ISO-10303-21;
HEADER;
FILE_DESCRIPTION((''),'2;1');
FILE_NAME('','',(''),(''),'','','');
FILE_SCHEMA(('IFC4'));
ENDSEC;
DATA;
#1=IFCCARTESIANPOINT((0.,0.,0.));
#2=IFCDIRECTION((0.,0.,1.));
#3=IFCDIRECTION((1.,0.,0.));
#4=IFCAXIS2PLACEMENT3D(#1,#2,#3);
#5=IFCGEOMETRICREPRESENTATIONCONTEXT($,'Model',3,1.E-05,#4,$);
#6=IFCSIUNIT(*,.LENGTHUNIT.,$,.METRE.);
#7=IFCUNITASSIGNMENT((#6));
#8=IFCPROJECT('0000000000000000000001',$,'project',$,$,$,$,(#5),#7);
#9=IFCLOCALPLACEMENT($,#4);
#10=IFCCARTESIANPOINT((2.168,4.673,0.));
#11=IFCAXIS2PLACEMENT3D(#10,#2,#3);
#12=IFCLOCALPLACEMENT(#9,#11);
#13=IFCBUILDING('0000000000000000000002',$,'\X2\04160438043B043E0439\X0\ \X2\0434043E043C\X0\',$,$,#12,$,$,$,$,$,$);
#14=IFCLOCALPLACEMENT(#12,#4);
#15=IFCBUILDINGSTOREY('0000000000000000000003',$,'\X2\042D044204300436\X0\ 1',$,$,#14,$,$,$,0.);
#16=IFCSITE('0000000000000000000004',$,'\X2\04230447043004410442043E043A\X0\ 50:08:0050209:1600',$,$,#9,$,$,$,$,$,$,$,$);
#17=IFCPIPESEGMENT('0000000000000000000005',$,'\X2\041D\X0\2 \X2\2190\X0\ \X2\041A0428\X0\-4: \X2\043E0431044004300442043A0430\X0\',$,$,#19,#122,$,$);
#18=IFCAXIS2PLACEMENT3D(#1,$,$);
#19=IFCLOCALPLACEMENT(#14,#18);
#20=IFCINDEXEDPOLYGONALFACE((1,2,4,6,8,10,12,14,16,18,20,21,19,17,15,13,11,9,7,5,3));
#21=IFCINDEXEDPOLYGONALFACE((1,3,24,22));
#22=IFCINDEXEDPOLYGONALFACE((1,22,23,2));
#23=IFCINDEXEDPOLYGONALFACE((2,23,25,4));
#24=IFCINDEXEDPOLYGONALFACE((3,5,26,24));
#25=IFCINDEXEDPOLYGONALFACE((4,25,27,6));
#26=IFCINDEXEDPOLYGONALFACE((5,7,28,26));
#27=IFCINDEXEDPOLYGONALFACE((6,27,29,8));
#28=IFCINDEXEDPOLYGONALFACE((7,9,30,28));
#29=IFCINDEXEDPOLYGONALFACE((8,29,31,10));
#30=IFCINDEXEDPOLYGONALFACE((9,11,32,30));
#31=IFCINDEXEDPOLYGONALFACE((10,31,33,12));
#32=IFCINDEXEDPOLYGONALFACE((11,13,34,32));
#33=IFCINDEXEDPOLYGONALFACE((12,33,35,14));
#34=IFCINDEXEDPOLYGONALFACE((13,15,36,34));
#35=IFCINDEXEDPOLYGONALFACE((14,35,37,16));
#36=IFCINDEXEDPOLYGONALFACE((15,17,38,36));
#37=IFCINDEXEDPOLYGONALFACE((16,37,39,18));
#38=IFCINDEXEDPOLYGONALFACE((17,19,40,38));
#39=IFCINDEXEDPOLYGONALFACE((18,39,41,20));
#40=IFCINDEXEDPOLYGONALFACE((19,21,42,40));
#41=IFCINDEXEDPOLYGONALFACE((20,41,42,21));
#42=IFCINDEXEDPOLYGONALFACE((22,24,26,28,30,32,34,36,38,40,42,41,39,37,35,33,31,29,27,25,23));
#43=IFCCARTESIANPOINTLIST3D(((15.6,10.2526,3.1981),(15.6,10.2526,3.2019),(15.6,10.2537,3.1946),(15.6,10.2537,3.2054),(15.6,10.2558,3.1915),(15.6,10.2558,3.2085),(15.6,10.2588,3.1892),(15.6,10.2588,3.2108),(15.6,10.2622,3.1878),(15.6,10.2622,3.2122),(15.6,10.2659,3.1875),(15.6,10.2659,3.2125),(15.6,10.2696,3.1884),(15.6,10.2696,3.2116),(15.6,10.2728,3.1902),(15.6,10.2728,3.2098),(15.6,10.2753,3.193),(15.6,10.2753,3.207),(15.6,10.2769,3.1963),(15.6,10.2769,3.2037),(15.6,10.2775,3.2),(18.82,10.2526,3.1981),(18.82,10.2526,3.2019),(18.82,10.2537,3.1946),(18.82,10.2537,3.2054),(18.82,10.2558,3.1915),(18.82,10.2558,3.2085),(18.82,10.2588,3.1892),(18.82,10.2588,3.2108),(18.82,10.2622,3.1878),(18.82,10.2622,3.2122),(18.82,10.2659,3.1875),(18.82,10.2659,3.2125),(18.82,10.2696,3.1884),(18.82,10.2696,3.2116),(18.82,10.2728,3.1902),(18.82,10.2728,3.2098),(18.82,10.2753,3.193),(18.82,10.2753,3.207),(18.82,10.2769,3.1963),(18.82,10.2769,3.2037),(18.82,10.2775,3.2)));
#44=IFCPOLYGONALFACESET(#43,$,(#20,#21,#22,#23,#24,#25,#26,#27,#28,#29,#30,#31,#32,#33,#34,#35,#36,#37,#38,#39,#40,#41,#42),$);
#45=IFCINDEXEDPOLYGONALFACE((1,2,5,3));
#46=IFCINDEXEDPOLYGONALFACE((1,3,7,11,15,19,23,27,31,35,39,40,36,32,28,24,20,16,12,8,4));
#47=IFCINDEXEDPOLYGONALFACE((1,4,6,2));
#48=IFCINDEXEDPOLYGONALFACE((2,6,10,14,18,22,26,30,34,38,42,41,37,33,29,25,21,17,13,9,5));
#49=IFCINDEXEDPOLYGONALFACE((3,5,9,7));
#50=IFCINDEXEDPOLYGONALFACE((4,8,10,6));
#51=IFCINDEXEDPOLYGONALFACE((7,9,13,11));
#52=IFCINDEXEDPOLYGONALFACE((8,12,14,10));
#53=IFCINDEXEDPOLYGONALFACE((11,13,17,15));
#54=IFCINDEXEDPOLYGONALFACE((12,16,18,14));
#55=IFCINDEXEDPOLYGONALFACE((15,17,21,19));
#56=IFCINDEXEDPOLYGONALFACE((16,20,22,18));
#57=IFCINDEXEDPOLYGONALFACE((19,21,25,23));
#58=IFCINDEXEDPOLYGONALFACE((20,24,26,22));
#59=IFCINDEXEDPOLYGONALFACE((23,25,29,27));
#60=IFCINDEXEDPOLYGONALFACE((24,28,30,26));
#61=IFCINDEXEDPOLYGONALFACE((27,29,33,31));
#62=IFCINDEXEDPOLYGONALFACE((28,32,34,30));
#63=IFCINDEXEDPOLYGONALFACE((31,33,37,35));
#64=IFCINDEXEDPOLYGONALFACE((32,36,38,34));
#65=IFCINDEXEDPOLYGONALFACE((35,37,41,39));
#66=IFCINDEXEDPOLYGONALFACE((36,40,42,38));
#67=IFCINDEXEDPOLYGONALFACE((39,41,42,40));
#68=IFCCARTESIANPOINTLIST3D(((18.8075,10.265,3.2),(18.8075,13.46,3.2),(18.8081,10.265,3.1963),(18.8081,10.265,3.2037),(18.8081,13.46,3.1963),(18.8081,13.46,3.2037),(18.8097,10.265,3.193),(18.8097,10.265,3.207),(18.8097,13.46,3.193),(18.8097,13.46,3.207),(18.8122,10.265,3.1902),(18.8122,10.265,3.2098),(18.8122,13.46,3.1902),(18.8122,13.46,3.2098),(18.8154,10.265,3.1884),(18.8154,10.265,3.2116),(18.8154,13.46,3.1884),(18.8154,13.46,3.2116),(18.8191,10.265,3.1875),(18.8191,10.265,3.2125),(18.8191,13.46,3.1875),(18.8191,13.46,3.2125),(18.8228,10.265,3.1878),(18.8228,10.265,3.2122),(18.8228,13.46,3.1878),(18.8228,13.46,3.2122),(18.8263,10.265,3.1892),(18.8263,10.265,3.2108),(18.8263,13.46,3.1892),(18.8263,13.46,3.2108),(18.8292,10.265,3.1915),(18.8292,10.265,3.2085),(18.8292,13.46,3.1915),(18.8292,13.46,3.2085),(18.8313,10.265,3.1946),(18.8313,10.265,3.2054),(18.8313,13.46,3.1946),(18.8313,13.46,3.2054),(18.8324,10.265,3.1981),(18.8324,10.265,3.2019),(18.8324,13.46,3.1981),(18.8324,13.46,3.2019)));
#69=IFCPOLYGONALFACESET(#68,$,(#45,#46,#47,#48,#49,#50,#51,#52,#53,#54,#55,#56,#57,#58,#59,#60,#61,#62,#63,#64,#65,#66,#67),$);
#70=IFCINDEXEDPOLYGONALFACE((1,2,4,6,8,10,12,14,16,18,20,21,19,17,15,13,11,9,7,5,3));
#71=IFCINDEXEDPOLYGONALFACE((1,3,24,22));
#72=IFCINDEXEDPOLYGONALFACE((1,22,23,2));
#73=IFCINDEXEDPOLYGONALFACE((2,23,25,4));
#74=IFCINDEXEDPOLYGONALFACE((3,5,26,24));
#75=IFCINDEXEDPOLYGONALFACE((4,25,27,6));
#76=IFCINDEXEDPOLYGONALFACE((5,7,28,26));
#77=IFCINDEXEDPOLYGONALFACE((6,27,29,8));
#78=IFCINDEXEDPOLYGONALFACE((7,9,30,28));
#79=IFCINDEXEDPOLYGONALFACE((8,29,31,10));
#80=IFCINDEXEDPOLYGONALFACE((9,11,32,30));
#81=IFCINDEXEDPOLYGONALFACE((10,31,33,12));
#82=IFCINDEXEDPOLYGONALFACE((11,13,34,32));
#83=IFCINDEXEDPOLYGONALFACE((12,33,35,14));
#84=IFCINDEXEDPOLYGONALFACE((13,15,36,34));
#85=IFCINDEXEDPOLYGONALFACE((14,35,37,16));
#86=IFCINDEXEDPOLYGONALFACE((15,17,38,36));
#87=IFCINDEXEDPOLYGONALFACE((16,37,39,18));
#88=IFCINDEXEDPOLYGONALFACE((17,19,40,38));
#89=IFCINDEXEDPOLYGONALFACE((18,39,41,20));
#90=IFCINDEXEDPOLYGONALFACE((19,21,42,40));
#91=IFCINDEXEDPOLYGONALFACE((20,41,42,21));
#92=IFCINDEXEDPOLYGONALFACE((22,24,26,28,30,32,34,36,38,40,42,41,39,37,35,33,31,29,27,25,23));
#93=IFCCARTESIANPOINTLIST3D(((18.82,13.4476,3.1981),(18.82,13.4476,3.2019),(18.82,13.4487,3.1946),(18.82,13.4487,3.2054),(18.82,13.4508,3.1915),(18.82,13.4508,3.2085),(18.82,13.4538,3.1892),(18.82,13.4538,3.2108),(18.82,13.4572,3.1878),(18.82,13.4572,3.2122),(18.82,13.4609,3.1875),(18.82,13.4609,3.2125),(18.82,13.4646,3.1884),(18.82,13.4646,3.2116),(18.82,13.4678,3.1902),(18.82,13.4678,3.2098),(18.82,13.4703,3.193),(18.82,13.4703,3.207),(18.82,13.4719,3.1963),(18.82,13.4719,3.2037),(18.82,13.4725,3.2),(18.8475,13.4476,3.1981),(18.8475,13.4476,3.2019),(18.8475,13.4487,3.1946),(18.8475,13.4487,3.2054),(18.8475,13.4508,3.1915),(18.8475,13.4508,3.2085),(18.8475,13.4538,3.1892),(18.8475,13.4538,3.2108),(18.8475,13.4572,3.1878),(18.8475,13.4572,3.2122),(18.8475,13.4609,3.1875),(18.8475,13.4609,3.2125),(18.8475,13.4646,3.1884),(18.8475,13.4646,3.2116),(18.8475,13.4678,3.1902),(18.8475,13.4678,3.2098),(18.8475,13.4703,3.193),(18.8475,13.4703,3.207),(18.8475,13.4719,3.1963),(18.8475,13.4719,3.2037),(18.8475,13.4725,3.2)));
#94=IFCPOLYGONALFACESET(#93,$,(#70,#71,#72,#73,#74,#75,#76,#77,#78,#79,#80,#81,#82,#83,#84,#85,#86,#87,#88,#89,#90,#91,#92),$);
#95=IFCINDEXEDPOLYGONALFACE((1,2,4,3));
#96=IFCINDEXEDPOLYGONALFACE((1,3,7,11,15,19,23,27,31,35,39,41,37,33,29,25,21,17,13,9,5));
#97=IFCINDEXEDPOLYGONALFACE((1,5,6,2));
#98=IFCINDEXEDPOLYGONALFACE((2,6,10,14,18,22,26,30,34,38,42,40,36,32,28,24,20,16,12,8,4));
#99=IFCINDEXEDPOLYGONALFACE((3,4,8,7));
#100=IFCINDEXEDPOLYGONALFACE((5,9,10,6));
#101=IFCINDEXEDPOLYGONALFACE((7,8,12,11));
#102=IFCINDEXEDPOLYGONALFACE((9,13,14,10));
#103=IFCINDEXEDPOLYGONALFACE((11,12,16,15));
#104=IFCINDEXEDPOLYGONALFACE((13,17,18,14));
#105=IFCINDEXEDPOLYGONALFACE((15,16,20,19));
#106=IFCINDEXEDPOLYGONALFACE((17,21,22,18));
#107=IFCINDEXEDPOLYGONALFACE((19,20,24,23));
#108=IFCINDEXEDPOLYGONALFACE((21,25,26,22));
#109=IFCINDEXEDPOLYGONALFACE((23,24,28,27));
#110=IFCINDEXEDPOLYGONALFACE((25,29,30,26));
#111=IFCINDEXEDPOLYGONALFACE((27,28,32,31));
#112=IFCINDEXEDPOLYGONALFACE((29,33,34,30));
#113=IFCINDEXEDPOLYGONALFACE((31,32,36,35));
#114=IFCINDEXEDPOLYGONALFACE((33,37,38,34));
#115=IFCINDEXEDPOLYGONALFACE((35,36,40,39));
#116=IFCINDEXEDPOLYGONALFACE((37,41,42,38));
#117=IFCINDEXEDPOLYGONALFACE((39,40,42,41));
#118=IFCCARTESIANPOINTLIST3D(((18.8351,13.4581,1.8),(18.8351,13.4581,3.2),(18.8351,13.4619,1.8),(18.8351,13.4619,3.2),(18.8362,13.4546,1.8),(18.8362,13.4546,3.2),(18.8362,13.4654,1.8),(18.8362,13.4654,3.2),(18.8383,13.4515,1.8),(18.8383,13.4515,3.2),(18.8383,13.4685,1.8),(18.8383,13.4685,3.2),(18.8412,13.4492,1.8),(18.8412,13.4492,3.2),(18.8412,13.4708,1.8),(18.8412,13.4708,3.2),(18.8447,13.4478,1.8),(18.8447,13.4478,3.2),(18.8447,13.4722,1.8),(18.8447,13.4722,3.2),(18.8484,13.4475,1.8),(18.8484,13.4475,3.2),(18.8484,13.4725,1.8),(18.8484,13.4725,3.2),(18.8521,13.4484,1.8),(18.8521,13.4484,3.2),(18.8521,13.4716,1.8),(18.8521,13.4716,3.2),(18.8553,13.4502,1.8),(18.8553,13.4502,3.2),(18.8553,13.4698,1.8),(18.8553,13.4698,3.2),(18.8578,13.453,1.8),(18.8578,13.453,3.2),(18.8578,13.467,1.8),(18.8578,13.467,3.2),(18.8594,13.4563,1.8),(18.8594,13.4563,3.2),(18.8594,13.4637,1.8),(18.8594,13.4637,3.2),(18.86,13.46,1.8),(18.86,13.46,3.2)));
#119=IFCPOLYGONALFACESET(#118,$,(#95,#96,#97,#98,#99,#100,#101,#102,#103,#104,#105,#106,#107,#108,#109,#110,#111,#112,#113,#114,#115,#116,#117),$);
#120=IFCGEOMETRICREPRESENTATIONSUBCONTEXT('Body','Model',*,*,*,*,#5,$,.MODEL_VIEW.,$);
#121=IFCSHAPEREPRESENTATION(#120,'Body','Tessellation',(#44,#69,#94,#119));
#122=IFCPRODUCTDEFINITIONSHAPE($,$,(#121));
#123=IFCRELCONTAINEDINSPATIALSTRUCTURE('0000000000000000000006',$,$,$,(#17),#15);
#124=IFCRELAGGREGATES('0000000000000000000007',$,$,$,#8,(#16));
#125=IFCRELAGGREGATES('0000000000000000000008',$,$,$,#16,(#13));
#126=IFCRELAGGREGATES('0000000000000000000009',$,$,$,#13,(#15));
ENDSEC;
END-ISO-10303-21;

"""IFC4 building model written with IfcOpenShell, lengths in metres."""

from ifc_helpers import new_model, si_unit, frame, origin_with_axes, origin_2d, place, context, subcontext, project, spatial, circle, extrude, element, save


model = new_model("IFC4")

# Units and contexts
model_context = context("Model", 3, precision=1e-05, world=origin_with_axes())
body_context = subcontext(model_context, "Body", "Model", "MODEL_VIEW")
ifc_project = project(units=[si_unit("LENGTHUNIT", "METRE")], contexts=[model_context])

# Site, building, storey
site_placement = place(None, origin_with_axes())
site = spatial("IfcSite", under=ifc_project, at=site_placement, Name="Участок 50:08:0050209:1600")
building_placement = place(site_placement, frame((2.168, 4.673, 0.0), z_axis=(0.0, 0.0, 1.0), x_axis=(1.0, 0.0, 0.0)))
building = spatial("IfcBuilding", under=site, at=building_placement, Name="Жилой дом")
storey_placement = place(building_placement, origin_with_axes())
storey = spatial("IfcBuildingStorey", under=building, at=storey_placement, Name="Этаж 1", Elevation=0.0)

# Pipe segment
pipe_segment_1_placement = place(storey_placement, origin_with_axes())
element("IfcPipeSegment", 1, at=pipe_segment_1_placement, inside=storey, Name="Н2 ← КШ-4: обратка", context=body_context, shape_type="SweptSolid", body=[
    extrude(circle(Radius=0.0125, at=origin_2d()), frame((15.6, 10.265, 3.2), z_axis=(1.0, 0.0, 0.0), x_axis=(0.0, 1.0, 0.0)), (0.0, 0.0, 1.0), 3.22),
    extrude(circle(Radius=0.0125, at=origin_2d()), frame((18.82, 10.265, 3.2), z_axis=(0.0, 1.0, 0.0), x_axis=(-1.0, 0.0, 0.0)), (0.0, 0.0, 1.0), 3.195),
    extrude(circle(Radius=0.0125, at=origin_2d()), frame((18.82, 13.46, 3.2), z_axis=(1.0, 0.0, 0.0), x_axis=(0.0, 1.0, 0.0)), (0.0, 0.0, 1.0), 0.0275),
    extrude(circle(Radius=0.0125, at=origin_2d()), frame((18.8475, 13.46, 3.2), z_axis=(0.0, 0.0, -1.0), x_axis=(1.0, 0.0, 0.0)), (0.0, 0.0, 1.0), 1.4),
])

save(model, "model.ifc")
